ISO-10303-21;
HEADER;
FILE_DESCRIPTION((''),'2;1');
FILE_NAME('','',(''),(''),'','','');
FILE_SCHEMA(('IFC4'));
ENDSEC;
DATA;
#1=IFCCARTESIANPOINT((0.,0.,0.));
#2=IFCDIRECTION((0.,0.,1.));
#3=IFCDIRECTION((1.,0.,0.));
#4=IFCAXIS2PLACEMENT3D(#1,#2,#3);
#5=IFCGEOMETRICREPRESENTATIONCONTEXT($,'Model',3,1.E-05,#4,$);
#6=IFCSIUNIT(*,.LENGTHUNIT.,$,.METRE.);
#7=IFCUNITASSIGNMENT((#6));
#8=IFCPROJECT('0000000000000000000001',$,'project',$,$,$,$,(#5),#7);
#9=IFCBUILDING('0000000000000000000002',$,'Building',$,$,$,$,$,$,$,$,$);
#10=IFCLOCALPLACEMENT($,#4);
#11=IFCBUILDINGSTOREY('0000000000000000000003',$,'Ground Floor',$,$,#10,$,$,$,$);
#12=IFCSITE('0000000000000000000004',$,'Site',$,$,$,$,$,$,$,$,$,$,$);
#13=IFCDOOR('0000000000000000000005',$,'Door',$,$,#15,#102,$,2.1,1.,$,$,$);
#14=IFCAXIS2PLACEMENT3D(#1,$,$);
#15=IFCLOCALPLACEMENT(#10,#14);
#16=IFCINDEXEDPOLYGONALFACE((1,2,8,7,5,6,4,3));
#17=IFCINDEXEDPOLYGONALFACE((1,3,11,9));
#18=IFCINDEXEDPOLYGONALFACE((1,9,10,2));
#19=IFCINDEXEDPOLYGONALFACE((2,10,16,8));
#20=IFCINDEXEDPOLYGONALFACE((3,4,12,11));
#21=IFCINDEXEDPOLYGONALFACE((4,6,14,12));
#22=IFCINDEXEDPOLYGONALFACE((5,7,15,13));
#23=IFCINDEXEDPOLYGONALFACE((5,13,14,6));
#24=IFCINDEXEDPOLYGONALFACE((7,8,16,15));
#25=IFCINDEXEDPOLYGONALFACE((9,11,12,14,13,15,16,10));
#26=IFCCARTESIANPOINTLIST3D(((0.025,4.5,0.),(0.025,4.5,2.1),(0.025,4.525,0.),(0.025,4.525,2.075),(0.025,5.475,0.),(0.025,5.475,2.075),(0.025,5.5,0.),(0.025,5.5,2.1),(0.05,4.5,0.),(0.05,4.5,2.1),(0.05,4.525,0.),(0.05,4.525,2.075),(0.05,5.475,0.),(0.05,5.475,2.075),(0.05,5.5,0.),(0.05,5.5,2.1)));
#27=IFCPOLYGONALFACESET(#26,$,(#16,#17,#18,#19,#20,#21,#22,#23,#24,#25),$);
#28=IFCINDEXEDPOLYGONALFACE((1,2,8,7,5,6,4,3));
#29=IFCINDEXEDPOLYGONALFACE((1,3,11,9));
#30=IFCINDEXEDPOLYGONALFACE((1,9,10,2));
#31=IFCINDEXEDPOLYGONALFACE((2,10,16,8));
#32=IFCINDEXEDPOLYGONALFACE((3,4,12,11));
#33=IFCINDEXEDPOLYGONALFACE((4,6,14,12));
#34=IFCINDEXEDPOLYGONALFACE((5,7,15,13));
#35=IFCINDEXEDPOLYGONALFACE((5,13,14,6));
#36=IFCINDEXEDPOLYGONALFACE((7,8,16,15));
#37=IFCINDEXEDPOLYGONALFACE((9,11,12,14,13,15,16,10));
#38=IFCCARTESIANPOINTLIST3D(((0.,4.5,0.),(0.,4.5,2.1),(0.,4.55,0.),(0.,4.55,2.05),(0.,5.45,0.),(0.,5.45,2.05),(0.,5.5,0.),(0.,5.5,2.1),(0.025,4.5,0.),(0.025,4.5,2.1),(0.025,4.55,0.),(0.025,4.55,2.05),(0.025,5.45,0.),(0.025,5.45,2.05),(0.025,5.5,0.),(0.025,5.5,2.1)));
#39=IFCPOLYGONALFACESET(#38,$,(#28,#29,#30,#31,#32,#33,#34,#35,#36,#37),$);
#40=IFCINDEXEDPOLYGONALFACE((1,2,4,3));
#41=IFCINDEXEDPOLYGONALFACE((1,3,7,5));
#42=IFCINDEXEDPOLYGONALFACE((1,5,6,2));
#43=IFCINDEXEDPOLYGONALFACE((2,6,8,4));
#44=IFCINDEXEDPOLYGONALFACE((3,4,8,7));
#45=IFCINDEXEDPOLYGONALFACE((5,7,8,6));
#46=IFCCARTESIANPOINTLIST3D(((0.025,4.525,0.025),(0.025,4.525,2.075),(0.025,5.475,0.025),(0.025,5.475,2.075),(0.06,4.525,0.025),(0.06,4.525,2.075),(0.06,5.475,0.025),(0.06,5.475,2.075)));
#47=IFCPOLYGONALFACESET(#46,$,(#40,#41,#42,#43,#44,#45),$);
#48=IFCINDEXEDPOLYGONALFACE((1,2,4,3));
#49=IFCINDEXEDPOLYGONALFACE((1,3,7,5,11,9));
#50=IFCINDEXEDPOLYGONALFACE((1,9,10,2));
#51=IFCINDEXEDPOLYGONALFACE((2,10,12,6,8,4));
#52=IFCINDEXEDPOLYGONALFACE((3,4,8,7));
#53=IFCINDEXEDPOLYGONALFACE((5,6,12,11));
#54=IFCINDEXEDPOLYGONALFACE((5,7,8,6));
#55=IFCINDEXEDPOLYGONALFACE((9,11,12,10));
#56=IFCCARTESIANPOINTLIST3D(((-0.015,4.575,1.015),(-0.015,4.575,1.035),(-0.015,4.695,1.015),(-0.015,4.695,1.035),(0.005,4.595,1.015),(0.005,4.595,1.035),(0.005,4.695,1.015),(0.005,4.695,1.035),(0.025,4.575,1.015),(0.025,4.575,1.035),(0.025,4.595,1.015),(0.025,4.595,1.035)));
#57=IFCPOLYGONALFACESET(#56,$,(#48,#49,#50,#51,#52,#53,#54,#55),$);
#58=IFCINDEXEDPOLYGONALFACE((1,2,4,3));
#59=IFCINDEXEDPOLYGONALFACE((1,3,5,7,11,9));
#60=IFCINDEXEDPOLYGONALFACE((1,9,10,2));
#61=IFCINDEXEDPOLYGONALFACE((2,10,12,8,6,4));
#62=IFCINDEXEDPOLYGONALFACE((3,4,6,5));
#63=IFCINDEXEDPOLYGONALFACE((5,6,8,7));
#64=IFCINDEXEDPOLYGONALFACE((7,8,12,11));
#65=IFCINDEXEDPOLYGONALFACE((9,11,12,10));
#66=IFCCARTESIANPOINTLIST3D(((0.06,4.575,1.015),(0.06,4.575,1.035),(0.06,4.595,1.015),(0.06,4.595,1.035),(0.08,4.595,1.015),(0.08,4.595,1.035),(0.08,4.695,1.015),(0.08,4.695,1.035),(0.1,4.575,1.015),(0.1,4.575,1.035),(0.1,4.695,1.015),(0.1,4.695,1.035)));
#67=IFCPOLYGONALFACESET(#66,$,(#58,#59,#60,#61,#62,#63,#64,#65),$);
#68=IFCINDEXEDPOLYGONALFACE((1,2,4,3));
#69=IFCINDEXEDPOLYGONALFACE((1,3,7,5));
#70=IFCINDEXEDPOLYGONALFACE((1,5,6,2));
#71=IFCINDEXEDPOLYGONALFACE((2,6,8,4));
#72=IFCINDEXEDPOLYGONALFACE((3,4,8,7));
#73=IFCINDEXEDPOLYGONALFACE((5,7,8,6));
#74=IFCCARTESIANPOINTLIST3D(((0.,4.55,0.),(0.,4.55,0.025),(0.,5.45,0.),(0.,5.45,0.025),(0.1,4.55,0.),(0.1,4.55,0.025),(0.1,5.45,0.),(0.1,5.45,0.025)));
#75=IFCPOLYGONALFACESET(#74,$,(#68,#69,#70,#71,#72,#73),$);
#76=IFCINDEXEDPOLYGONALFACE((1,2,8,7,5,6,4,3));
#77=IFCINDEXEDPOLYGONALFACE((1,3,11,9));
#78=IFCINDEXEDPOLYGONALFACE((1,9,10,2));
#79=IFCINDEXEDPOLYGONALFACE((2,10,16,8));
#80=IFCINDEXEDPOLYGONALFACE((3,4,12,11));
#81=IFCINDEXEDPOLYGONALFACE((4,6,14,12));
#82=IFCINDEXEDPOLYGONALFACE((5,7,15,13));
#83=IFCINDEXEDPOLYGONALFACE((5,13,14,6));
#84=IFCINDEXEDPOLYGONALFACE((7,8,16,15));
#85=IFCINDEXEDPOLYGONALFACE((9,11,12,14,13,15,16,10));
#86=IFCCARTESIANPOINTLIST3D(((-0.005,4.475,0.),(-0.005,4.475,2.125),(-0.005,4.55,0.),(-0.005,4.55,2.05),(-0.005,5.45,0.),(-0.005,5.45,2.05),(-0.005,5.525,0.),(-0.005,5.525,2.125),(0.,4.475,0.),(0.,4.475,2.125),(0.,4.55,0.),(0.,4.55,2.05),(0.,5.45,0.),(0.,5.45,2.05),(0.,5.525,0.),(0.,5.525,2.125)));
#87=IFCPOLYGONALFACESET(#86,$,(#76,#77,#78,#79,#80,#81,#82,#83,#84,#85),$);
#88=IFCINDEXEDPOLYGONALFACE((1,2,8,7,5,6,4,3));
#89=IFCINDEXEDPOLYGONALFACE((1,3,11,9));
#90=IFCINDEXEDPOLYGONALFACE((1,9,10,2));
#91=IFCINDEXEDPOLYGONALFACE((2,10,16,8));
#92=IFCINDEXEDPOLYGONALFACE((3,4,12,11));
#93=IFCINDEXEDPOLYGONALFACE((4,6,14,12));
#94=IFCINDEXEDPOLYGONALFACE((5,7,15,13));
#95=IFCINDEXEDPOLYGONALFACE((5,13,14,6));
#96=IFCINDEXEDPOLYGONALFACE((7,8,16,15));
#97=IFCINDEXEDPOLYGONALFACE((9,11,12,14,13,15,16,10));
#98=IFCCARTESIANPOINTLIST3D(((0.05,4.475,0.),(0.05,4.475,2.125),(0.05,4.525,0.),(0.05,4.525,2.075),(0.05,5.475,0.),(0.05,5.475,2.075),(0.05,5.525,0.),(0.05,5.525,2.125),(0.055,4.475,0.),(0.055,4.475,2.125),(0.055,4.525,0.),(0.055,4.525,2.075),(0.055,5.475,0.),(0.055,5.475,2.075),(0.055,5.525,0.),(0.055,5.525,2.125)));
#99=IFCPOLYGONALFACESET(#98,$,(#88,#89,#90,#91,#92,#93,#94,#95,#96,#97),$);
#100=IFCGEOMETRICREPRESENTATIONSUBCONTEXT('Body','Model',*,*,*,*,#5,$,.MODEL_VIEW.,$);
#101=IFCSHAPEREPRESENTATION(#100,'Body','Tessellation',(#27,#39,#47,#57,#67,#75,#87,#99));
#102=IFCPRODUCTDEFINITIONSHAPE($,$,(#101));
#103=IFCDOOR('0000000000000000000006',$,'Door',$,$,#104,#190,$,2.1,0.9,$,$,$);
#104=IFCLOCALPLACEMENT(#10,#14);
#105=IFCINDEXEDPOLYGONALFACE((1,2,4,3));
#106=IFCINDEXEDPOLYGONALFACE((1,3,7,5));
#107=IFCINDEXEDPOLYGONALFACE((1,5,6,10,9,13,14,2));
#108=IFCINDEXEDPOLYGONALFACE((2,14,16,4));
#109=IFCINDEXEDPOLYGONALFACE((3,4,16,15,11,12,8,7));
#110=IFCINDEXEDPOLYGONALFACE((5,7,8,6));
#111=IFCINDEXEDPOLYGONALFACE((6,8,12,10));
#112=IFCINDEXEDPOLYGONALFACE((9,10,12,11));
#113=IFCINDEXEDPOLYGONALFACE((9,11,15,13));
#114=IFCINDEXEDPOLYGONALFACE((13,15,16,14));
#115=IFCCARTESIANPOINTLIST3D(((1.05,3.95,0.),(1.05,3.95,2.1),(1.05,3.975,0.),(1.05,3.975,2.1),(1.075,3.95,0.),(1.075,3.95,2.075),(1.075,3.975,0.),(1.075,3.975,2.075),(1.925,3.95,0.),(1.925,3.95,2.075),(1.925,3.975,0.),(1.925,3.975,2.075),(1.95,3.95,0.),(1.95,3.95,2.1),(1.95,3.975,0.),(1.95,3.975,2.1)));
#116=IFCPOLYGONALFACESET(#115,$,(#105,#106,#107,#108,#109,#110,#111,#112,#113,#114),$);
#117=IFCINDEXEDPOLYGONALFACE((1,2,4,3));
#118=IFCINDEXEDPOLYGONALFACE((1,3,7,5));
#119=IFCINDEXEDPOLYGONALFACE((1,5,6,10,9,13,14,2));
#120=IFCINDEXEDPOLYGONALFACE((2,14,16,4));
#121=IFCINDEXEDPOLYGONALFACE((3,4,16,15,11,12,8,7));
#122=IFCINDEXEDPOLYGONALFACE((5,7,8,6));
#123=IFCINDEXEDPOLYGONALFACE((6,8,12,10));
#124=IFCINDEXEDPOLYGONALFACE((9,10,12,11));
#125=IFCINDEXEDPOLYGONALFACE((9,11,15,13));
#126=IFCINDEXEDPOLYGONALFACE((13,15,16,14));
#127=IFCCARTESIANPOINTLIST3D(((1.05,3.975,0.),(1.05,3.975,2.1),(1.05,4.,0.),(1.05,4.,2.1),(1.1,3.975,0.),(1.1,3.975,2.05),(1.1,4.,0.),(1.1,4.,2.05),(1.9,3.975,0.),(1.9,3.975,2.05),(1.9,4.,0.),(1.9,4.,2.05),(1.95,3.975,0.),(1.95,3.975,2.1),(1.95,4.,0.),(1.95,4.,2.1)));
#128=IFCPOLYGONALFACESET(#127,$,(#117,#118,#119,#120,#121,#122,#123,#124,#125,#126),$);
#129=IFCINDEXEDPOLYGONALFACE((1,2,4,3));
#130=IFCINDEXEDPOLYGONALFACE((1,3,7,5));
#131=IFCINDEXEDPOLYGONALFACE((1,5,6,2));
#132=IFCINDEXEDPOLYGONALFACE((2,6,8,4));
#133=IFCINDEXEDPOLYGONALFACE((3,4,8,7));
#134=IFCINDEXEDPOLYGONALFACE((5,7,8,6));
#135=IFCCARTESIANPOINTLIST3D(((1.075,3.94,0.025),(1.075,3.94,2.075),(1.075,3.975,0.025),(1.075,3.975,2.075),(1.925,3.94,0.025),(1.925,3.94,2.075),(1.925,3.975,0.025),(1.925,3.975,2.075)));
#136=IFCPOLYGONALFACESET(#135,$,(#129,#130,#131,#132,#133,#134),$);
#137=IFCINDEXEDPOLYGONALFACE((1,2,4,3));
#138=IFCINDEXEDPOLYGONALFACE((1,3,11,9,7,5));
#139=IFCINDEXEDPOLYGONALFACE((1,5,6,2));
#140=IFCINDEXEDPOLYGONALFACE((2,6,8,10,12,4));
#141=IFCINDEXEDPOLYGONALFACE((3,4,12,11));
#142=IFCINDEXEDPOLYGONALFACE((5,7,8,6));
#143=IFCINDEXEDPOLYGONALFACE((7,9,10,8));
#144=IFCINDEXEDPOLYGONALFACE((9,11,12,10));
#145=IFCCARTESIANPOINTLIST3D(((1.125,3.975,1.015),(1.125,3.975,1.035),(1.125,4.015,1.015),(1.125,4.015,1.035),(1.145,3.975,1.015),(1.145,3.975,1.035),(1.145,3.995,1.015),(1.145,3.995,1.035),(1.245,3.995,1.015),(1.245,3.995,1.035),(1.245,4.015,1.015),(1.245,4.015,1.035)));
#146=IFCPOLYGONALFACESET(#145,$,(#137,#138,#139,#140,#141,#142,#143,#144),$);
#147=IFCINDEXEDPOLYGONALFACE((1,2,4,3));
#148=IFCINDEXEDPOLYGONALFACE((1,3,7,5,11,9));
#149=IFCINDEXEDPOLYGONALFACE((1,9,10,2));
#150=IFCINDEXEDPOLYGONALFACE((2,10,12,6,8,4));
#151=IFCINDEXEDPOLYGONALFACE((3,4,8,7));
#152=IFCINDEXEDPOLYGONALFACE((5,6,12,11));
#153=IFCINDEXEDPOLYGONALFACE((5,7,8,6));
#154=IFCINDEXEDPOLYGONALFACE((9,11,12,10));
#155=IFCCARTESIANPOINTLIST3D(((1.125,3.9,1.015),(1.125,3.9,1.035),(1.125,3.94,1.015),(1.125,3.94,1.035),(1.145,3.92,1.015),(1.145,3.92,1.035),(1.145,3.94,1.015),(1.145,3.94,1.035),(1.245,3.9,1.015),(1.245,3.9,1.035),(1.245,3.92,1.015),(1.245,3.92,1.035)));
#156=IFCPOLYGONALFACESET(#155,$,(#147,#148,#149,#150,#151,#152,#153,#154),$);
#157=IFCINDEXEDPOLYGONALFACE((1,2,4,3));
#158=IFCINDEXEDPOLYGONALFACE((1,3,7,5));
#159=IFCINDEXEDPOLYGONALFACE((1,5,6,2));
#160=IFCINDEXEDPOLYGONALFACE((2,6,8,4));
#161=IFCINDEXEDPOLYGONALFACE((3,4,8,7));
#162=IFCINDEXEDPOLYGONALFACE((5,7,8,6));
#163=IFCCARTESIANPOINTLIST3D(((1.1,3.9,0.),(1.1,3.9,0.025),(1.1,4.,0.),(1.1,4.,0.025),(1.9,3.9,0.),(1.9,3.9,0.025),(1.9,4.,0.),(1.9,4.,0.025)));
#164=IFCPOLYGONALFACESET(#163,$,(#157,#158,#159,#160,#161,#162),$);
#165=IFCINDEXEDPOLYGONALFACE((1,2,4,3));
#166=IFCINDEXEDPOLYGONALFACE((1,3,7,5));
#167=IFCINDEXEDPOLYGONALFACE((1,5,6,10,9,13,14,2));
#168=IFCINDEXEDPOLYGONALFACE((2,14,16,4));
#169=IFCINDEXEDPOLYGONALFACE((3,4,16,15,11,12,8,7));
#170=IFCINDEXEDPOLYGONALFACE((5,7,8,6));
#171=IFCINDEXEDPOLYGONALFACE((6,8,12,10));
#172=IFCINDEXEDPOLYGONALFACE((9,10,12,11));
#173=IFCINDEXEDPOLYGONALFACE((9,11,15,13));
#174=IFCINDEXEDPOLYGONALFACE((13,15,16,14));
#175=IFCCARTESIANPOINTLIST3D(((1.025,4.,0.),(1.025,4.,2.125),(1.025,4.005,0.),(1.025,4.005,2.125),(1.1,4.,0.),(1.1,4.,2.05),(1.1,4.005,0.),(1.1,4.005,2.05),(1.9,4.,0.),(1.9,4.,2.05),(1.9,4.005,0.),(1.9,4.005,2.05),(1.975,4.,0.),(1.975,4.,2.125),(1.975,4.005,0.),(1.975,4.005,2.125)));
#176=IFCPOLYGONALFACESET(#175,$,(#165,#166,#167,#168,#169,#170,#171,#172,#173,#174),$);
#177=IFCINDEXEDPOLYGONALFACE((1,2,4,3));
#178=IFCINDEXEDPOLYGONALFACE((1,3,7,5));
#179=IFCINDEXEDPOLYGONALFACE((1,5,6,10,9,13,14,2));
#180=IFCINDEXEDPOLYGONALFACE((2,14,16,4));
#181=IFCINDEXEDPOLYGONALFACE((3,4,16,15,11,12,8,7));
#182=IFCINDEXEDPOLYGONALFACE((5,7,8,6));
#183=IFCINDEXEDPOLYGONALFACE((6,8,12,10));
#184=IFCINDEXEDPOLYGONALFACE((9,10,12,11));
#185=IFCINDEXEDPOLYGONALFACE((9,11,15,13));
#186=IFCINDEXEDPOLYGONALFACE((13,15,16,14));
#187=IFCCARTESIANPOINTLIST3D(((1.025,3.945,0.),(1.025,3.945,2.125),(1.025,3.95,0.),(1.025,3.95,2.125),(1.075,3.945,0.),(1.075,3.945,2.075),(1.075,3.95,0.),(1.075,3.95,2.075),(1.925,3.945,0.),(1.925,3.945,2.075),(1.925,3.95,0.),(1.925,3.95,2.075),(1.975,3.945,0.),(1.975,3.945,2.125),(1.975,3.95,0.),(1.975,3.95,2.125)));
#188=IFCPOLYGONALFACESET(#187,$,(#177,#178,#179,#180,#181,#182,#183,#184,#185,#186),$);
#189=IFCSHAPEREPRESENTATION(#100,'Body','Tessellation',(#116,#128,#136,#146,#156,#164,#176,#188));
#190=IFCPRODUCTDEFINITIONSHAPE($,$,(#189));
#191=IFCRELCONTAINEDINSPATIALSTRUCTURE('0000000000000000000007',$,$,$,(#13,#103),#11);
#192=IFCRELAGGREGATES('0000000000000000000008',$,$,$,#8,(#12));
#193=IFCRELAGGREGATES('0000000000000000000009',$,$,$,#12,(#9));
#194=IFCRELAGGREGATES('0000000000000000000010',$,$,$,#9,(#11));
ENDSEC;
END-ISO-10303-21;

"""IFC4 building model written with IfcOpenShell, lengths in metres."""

from ifc_helpers import new_model, si_unit, frame, origin_with_axes, place, context, subcontext, project, spatial, line, indexed_curve, outline, extrude, element, save


model = new_model("IFC4")

# Units and contexts
model_context = context("Model", 3, precision=1e-05, world=origin_with_axes())
body_context = subcontext(model_context, "Body", "Model", "MODEL_VIEW")
ifc_project = project(units=[si_unit("LENGTHUNIT", "METRE")], contexts=[model_context])

# Site, building, storey
site = spatial("IfcSite", under=ifc_project, Name="Site")
building = spatial("IfcBuilding", under=site, Name="Building")
storey_placement = place(None, origin_with_axes())
storey = spatial("IfcBuildingStorey", under=building, at=storey_placement, Name="Ground Floor")

# Doors
door_1_placement = place(storey_placement, frame((0.0, 5.5, 0.0), z_axis=(0.0, 0.0, 1.0), x_axis=(0.0, -1.0, 0.0)))
element("IfcDoor", 1, at=door_1_placement, inside=storey, Name="Door", OverallHeight=2.1, OverallWidth=1.0, context=body_context, shape_type="SweptSolid", body=[
    extrude(outline(indexed_curve([(0.0, 0.0), (0.0, 2.1), (1.0, 2.1), (1.0, 0.0), (0.975, 0.0), (0.975, 2.075), (0.025, 2.075), (0.025, 0.0)], segments=[line(1, 2, 3, 4, 5, 6, 7, 8, 1)])), frame((0.0, 0.025, 0.0), z_axis=(0.0, -1.0, 0.0), x_axis=(1.0, 0.0, 0.0)), (0.0, 0.0, -1.0), 0.025),
    extrude(outline(indexed_curve([(0.0, 0.0), (0.0, 2.1), (1.0, 2.1), (1.0, 0.0), (0.95, 0.0), (0.95, 2.05), (0.05, 2.05), (0.05, 0.0)], segments=[line(1, 2, 3, 4, 5, 6, 7, 8, 1)])), frame((0.0, 0.0, 0.0), z_axis=(0.0, -1.0, 0.0), x_axis=(1.0, 0.0, 0.0)), (0.0, 0.0, -1.0), 0.025),
    extrude(outline(indexed_curve([(0.0, 0.0), (0.95, 0.0), (0.95, 0.035), (0.0, 0.035)], segments=[line(1, 2, 3, 4, 1)])), frame((0.025, 0.025, 0.025), z_axis=(0.0, 0.0, 1.0), x_axis=(1.0, 0.0, 0.0)), (0.0, 0.0, 1.0), 2.05),
    extrude(outline(indexed_curve([(0.0, 0.0), (0.0, -0.04), (-0.12, -0.04), (-0.12, -0.02), (-0.02, -0.02), (-0.02, 0.0)], segments=[line(1, 2, 3, 4, 5, 6, 1)])), frame((0.925, 0.025, 1.015), z_axis=(0.0, 0.0, 1.0), x_axis=(1.0, 0.0, 0.0)), (0.0, 0.0, 1.0), 0.02),
    extrude(outline(indexed_curve([(0.0, 0.0), (0.0, 0.04), (-0.12, 0.04), (-0.12, 0.02), (-0.02, 0.02), (-0.02, 0.0)], segments=[line(1, 2, 3, 4, 5, 6, 1)])), frame((0.925, 0.06, 1.015), z_axis=(0.0, 0.0, 1.0), x_axis=(1.0, 0.0, 0.0)), (0.0, 0.0, 1.0), 0.02),
    extrude(outline(indexed_curve([(0.0, 0.0), (0.9, 0.0), (0.9, 0.1), (0.0, 0.1)], segments=[line(1, 2, 3, 4, 1)])), frame((0.05, 0.0, 0.0), z_axis=(0.0, 0.0, 1.0), x_axis=(1.0, 0.0, 0.0)), (0.0, 0.0, 1.0), 0.025),
    extrude(outline(indexed_curve([(0.0, 0.0), (0.0, 2.125), (1.05, 2.125), (1.05, 0.0), (0.975, 0.0), (0.975, 2.05), (0.075, 2.05), (0.075, 0.0)], segments=[line(1, 2, 3, 4, 5, 6, 7, 8, 1)])), frame((-0.025, -0.005, 0.0), z_axis=(0.0, -1.0, 0.0), x_axis=(1.0, 0.0, 0.0)), (0.0, 0.0, -1.0), 0.005),
    extrude(outline(indexed_curve([(0.0, 0.0), (0.0, 2.125), (1.05, 2.125), (1.05, 0.0), (1.0, 0.0), (1.0, 2.075), (0.05, 2.075), (0.05, 0.0)], segments=[line(1, 2, 3, 4, 5, 6, 7, 8, 1)])), frame((-0.025, 0.05, 0.0), z_axis=(0.0, -1.0, 0.0), x_axis=(1.0, 0.0, 0.0)), (0.0, 0.0, -1.0), 0.005),
])
door_2_placement = place(storey_placement, frame((1.95, 4.0, 0.0), z_axis=(0.0, 0.0, 1.0), x_axis=(-1.0, 0.0, 0.0)))
element("IfcDoor", 2, at=door_2_placement, inside=storey, Name="Door", OverallHeight=2.1, OverallWidth=0.9, context=body_context, shape_type="SweptSolid", body=[
    extrude(outline(indexed_curve([(0.0, 0.0), (0.0, 2.1), (0.9, 2.1), (0.9, 0.0), (0.875, 0.0), (0.875, 2.075), (0.025, 2.075), (0.025, 0.0)], segments=[line(1, 2, 3, 4, 5, 6, 7, 8, 1)])), frame((0.0, 0.025, 0.0), z_axis=(0.0, -1.0, 0.0), x_axis=(1.0, 0.0, 0.0)), (0.0, 0.0, -1.0), 0.025),
    extrude(outline(indexed_curve([(0.0, 0.0), (0.0, 2.1), (0.9, 2.1), (0.9, 0.0), (0.85, 0.0), (0.85, 2.05), (0.05, 2.05), (0.05, 0.0)], segments=[line(1, 2, 3, 4, 5, 6, 7, 8, 1)])), frame((0.0, 0.0, 0.0), z_axis=(0.0, -1.0, 0.0), x_axis=(1.0, 0.0, 0.0)), (0.0, 0.0, -1.0), 0.025),
    extrude(outline(indexed_curve([(0.0, 0.0), (0.85, 0.0), (0.85, 0.035), (0.0, 0.035)], segments=[line(1, 2, 3, 4, 1)])), frame((0.025, 0.025, 0.025), z_axis=(0.0, 0.0, 1.0), x_axis=(1.0, 0.0, 0.0)), (0.0, 0.0, 1.0), 2.05),
    extrude(outline(indexed_curve([(0.0, 0.0), (0.0, -0.04), (-0.12, -0.04), (-0.12, -0.02), (-0.02, -0.02), (-0.02, 0.0)], segments=[line(1, 2, 3, 4, 5, 6, 1)])), frame((0.825, 0.025, 1.015), z_axis=(0.0, 0.0, 1.0), x_axis=(1.0, 0.0, 0.0)), (0.0, 0.0, 1.0), 0.02),
    extrude(outline(indexed_curve([(0.0, 0.0), (0.0, 0.04), (-0.12, 0.04), (-0.12, 0.02), (-0.02, 0.02), (-0.02, 0.0)], segments=[line(1, 2, 3, 4, 5, 6, 1)])), frame((0.825, 0.06, 1.015), z_axis=(0.0, 0.0, 1.0), x_axis=(1.0, 0.0, 0.0)), (0.0, 0.0, 1.0), 0.02),
    extrude(outline(indexed_curve([(0.0, 0.0), (0.8, 0.0), (0.8, 0.1), (0.0, 0.1)], segments=[line(1, 2, 3, 4, 1)])), frame((0.05, 0.0, 0.0), z_axis=(0.0, 0.0, 1.0), x_axis=(1.0, 0.0, 0.0)), (0.0, 0.0, 1.0), 0.025),
    extrude(outline(indexed_curve([(0.0, 0.0), (0.0, 2.125), (0.95, 2.125), (0.95, 0.0), (0.875, 0.0), (0.875, 2.05), (0.075, 2.05), (0.075, 0.0)], segments=[line(1, 2, 3, 4, 5, 6, 7, 8, 1)])), frame((-0.025, -0.005, 0.0), z_axis=(0.0, -1.0, 0.0), x_axis=(1.0, 0.0, 0.0)), (0.0, 0.0, -1.0), 0.005),
    extrude(outline(indexed_curve([(0.0, 0.0), (0.0, 2.125), (0.95, 2.125), (0.95, 0.0), (0.9, 0.0), (0.9, 2.075), (0.05, 2.075), (0.05, 0.0)], segments=[line(1, 2, 3, 4, 5, 6, 7, 8, 1)])), frame((-0.025, 0.05, 0.0), z_axis=(0.0, -1.0, 0.0), x_axis=(1.0, 0.0, 0.0)), (0.0, 0.0, -1.0), 0.005),
])

save(model, "model.ifc")
